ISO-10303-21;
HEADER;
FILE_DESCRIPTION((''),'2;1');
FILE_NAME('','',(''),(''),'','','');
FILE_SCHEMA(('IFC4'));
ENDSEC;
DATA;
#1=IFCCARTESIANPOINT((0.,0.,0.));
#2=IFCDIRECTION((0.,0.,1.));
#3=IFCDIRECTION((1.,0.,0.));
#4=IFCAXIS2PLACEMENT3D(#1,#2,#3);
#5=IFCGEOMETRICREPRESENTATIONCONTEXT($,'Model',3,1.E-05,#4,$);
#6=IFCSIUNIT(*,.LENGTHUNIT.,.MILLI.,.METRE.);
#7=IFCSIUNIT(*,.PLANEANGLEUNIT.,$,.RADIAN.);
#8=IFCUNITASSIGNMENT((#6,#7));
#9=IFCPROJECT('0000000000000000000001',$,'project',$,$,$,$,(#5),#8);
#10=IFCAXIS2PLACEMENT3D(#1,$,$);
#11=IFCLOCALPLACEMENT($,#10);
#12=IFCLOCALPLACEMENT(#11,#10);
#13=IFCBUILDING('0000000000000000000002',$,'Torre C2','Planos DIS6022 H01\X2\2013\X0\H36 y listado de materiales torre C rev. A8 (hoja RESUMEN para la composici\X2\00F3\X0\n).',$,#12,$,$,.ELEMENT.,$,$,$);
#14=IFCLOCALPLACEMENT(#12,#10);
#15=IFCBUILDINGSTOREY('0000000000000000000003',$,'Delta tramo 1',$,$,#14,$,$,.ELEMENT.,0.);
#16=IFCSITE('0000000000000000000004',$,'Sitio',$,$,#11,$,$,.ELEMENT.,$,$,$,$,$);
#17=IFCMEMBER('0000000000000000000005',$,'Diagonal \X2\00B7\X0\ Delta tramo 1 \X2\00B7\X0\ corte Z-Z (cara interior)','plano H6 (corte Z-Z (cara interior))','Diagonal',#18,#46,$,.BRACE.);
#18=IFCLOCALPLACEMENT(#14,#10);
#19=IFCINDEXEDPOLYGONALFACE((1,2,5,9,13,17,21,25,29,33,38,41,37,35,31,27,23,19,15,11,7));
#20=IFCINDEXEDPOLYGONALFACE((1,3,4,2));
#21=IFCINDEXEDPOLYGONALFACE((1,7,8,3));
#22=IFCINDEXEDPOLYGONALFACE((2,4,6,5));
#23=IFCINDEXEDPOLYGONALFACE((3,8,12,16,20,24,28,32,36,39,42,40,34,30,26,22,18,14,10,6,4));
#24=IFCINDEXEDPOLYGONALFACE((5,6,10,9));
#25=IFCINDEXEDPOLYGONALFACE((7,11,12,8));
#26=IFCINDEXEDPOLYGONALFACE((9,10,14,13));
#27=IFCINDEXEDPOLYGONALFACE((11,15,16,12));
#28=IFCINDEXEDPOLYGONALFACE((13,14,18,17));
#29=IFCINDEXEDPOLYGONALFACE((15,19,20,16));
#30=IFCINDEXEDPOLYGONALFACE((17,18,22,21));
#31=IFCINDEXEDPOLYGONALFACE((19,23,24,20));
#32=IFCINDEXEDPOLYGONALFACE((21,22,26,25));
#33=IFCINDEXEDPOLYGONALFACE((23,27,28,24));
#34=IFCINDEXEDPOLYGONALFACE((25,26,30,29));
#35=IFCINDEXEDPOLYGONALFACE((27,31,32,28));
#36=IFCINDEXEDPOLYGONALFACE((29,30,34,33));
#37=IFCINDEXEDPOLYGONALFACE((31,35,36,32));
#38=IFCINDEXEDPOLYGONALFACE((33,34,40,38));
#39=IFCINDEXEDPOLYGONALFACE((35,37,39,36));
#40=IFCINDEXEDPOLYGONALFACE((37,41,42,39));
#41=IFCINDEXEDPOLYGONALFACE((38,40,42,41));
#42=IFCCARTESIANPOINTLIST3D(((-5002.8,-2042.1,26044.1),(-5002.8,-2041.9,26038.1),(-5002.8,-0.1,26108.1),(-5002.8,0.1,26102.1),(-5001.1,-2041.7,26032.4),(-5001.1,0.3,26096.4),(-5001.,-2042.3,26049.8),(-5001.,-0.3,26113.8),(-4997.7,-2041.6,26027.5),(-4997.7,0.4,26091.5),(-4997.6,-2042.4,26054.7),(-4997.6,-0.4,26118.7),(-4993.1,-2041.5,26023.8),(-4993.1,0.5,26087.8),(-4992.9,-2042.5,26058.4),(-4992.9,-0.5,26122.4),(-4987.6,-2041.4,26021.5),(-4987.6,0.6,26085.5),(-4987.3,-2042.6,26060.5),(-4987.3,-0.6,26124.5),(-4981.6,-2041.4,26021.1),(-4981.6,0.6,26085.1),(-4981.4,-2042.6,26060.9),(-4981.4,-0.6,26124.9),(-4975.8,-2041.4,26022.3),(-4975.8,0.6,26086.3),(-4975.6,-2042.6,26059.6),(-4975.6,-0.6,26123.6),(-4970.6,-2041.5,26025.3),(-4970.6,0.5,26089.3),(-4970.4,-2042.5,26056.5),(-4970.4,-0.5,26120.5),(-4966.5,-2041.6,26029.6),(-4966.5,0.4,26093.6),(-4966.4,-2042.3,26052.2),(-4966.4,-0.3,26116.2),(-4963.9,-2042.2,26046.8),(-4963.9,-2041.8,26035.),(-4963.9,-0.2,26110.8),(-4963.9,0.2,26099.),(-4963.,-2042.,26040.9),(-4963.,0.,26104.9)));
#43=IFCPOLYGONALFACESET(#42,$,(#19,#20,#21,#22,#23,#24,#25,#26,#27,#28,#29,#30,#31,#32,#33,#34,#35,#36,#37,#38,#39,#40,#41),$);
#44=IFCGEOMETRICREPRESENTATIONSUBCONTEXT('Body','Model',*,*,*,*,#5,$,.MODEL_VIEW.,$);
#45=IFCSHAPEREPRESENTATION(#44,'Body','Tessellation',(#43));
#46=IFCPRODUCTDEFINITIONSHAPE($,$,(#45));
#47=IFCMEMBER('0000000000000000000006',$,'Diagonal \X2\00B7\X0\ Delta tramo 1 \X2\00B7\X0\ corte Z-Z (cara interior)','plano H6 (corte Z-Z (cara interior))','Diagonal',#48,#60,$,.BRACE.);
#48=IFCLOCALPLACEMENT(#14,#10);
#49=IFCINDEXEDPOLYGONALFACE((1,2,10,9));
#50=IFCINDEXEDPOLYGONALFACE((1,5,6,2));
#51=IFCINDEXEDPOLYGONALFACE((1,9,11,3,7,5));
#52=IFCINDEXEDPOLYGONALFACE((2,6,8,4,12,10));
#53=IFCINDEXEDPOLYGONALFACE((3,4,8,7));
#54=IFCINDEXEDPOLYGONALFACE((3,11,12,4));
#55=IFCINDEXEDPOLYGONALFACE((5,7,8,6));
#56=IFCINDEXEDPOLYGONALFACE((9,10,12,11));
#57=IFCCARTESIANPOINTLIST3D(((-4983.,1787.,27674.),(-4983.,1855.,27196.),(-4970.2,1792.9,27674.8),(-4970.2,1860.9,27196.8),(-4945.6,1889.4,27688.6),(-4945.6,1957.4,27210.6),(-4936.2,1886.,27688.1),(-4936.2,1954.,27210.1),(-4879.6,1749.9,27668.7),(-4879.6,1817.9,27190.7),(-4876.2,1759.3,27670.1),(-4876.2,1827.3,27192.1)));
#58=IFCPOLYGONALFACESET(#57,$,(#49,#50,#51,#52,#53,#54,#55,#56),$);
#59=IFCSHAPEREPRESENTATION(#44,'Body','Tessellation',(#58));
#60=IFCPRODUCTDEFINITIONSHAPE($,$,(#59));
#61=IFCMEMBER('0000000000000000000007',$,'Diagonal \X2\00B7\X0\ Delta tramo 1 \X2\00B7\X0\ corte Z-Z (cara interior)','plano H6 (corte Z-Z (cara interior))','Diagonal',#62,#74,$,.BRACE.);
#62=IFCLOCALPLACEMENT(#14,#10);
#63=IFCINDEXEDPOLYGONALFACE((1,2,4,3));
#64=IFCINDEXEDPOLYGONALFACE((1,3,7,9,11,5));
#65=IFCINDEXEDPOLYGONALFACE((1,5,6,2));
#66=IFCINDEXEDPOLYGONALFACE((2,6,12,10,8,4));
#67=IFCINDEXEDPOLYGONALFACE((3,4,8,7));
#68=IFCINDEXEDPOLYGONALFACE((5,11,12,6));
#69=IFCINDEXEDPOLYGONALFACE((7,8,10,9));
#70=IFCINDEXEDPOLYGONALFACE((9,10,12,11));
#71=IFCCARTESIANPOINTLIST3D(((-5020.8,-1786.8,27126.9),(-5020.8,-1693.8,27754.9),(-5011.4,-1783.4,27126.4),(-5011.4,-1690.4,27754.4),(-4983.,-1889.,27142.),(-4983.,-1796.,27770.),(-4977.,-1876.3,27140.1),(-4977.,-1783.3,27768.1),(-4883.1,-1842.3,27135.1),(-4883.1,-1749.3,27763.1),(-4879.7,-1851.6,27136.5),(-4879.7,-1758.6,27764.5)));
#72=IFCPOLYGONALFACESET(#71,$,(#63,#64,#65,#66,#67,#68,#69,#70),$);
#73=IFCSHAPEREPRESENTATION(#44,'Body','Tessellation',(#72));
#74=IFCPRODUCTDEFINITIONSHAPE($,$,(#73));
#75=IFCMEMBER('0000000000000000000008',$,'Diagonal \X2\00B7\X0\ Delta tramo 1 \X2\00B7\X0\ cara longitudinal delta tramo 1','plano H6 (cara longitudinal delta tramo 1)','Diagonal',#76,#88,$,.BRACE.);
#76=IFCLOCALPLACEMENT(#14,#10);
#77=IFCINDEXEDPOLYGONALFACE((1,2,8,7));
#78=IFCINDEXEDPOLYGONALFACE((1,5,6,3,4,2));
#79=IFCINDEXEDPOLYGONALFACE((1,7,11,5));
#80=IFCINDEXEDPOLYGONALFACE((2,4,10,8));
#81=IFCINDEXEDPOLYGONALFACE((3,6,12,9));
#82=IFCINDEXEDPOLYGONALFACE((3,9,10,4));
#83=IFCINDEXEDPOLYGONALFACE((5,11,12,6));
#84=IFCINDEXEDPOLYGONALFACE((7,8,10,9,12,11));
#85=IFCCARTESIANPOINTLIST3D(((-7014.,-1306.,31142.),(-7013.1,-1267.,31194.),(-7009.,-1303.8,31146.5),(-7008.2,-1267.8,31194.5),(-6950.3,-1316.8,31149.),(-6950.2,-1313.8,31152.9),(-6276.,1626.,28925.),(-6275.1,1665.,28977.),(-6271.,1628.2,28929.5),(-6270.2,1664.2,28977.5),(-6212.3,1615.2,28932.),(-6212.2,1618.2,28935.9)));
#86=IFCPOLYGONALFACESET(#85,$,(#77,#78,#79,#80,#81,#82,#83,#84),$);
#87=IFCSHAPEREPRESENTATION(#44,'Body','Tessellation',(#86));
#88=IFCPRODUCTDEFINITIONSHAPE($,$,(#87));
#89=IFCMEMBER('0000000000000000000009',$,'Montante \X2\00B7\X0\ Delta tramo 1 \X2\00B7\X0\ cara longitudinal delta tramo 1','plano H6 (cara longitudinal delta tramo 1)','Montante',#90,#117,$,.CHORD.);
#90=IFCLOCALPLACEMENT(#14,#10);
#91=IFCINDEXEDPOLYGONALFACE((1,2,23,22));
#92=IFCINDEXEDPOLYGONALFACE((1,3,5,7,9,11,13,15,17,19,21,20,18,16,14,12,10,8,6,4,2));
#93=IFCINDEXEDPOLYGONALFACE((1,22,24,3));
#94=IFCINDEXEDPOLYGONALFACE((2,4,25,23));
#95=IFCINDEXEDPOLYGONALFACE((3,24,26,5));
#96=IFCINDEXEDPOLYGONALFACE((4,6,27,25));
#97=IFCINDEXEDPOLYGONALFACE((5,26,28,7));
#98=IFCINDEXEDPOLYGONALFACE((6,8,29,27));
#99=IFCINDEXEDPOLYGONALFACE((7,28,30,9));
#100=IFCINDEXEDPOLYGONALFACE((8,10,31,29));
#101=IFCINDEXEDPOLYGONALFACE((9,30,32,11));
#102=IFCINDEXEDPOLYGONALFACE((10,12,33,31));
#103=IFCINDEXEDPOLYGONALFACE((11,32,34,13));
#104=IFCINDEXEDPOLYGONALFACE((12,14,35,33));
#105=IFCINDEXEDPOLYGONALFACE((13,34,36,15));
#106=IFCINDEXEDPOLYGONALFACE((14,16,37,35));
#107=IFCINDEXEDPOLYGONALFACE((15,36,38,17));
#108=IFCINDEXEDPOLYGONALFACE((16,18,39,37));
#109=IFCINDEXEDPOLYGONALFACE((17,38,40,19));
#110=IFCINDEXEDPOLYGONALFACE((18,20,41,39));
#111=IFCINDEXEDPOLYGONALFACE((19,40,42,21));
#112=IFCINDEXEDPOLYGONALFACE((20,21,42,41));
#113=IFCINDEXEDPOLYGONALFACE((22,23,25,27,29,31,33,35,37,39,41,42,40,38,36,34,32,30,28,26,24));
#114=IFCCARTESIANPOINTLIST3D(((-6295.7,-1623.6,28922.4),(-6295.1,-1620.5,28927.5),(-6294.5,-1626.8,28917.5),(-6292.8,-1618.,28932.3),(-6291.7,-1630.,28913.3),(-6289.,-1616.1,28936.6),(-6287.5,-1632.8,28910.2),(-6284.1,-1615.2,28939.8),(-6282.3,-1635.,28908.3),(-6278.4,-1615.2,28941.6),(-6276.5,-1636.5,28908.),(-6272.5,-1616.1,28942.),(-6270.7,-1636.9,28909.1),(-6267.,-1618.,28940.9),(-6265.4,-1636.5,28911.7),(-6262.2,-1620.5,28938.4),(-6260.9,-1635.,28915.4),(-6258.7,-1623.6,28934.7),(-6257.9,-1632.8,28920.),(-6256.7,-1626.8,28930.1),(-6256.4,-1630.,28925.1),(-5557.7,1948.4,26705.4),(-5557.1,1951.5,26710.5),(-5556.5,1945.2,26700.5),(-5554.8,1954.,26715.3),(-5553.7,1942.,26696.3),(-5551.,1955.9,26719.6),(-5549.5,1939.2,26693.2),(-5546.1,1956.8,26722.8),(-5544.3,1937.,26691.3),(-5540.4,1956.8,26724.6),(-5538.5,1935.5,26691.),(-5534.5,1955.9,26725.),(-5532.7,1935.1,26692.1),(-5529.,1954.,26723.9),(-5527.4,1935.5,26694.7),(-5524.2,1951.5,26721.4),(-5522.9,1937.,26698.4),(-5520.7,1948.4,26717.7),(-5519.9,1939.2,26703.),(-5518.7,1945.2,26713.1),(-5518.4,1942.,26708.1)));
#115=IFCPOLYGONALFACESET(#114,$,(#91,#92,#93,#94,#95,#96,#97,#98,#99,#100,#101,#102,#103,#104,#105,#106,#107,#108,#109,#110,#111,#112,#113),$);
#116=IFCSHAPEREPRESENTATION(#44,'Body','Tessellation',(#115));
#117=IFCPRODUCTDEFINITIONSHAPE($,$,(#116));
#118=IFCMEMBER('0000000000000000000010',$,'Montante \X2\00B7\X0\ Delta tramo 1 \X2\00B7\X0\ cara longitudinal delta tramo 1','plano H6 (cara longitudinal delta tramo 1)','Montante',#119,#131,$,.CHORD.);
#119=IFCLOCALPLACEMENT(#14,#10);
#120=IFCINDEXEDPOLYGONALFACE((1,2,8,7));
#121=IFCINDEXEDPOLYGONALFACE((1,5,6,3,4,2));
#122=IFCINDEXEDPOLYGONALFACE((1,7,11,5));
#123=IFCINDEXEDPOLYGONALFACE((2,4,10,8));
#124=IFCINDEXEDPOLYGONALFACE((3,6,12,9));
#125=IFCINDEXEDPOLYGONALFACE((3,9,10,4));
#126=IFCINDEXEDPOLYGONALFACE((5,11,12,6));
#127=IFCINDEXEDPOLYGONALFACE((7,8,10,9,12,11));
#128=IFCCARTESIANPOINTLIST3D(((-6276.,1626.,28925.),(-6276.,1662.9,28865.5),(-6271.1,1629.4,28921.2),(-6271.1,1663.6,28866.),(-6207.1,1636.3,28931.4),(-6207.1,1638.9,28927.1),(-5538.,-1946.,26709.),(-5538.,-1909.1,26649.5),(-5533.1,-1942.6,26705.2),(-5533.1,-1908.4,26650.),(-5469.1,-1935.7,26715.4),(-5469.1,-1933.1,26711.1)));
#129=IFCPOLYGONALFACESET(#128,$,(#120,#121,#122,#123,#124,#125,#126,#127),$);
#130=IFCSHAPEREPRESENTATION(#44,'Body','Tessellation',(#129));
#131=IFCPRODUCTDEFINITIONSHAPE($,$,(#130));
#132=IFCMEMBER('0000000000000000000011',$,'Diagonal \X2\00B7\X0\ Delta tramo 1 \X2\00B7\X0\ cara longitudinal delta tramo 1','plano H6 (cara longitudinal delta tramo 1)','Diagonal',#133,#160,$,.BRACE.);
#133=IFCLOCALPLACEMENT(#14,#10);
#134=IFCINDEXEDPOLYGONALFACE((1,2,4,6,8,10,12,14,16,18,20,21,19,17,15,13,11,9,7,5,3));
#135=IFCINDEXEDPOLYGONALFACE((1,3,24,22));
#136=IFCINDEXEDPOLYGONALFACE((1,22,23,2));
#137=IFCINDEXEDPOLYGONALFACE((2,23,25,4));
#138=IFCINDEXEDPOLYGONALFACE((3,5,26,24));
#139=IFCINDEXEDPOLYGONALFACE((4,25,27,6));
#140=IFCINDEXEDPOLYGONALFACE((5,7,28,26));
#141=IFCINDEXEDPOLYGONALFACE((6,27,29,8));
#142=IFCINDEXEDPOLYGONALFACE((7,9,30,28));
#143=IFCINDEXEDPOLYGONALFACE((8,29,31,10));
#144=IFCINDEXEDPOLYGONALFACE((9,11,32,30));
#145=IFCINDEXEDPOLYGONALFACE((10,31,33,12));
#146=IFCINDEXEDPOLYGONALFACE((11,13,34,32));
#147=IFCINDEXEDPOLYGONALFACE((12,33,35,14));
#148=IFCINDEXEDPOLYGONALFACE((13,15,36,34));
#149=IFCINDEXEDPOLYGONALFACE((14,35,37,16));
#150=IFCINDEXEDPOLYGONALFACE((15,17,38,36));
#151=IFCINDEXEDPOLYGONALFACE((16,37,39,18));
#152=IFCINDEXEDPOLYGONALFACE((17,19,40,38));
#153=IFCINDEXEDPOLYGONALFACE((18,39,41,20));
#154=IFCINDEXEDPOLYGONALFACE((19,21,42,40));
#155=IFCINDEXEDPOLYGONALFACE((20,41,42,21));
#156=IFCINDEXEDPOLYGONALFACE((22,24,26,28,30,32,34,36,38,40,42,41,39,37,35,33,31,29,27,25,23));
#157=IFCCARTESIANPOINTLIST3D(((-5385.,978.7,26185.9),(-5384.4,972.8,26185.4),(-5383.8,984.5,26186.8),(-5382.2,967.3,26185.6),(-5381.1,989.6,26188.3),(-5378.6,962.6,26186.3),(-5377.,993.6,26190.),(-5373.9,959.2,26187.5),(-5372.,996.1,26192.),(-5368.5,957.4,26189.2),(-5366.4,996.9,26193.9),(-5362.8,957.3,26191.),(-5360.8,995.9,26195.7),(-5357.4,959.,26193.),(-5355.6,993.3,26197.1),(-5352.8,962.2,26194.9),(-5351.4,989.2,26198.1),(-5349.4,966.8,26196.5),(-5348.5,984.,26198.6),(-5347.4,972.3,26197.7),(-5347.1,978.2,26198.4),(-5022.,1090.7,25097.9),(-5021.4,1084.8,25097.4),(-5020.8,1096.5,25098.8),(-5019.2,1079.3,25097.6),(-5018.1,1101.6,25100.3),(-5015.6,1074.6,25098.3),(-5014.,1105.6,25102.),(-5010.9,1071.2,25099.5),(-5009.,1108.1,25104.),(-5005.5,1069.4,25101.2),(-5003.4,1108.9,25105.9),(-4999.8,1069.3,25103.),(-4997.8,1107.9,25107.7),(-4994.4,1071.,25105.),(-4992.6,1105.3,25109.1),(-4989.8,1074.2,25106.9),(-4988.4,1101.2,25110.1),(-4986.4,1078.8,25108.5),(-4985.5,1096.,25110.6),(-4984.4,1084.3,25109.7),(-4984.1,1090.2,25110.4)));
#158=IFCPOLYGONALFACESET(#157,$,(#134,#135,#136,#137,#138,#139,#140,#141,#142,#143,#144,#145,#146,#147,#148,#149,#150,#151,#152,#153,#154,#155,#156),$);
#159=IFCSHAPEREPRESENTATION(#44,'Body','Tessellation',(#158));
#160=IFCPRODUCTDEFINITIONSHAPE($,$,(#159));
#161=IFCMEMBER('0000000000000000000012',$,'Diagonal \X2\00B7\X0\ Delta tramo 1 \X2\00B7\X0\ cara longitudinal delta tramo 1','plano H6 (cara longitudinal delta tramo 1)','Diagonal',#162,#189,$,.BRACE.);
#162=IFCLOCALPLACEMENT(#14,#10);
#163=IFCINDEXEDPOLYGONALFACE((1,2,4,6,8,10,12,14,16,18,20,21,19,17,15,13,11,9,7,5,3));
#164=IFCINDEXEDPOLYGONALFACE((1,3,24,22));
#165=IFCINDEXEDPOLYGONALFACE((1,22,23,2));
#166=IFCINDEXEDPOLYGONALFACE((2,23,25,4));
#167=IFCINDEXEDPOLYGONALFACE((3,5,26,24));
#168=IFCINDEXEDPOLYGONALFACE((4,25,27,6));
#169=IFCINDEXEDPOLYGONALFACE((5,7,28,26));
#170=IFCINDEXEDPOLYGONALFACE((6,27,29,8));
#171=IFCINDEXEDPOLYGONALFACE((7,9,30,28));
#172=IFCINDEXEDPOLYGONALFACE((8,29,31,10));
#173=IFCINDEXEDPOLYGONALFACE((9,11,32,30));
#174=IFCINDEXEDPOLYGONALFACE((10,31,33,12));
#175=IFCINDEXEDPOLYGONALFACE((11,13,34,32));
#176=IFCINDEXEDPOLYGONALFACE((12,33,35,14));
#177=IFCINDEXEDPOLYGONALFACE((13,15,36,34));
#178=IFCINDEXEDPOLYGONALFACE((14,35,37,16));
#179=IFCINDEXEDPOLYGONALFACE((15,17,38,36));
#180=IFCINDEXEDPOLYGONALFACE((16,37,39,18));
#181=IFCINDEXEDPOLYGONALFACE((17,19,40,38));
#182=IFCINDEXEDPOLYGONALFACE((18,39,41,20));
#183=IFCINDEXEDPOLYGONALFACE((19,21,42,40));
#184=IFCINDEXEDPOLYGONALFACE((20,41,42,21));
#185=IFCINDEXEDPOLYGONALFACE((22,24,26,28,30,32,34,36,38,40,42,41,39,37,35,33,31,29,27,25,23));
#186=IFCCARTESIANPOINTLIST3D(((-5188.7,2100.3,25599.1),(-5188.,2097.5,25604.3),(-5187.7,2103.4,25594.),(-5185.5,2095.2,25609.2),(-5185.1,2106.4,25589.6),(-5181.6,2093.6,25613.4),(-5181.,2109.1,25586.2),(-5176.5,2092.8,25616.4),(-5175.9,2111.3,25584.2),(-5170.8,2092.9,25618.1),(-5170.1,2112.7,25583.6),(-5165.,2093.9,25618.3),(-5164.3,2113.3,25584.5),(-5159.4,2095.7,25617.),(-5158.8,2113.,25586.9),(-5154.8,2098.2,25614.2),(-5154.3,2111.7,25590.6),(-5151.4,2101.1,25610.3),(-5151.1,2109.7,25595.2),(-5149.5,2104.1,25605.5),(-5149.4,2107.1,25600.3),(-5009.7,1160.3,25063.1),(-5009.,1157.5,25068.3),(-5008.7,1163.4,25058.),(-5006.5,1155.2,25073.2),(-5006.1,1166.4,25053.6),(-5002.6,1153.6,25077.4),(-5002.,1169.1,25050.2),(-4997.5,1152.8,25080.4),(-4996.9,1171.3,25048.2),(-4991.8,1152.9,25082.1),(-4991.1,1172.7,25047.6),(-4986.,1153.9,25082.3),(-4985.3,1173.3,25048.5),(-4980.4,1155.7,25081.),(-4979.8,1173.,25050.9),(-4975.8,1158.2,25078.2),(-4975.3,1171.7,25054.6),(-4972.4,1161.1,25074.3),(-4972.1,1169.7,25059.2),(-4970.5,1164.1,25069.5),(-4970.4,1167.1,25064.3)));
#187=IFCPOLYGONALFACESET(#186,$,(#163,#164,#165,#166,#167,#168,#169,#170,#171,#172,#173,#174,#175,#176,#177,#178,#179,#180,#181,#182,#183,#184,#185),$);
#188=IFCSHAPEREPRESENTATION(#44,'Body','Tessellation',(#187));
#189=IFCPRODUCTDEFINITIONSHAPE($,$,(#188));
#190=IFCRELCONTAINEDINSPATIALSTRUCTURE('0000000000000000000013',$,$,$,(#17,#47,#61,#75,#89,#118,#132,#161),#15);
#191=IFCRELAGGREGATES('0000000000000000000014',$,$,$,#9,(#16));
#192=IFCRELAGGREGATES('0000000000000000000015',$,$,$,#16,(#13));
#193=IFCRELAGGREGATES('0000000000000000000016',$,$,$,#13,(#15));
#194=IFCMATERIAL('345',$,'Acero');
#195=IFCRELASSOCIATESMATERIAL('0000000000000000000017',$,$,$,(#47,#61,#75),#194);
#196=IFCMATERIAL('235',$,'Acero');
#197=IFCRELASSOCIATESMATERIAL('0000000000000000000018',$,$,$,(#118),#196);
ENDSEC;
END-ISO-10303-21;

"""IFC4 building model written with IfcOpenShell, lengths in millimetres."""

from ifc_helpers import new_model, si_unit, frame, frame_2d, origin, origin_with_axes, place, context, subcontext, project, spatial, circle, l_section, extrude, material, element, save


model = new_model("IFC4")

# Units and contexts
model_context = context("Model", 3, precision=1e-05, world=origin_with_axes())
body_context = subcontext(model_context, "Body", "Model", "MODEL_VIEW")
ifc_project = project(units=[si_unit("LENGTHUNIT", "METRE", prefix="MILLI"), si_unit("PLANEANGLEUNIT", "RADIAN")], contexts=[model_context])

# Site, building, storey
site_placement = place(None, origin())
site = spatial("IfcSite", under=ifc_project, at=site_placement, Name="Sitio", CompositionType="ELEMENT")
building_placement = place(site_placement, origin())
building = spatial("IfcBuilding", under=site, at=building_placement, Name="Torre C2", Description="Planos DIS6022 H01–H36 y listado de materiales torre C rev. A8 (hoja RESUMEN para la composición).", CompositionType="ELEMENT")
storey_placement = place(building_placement, origin())
storey = spatial("IfcBuildingStorey", under=building, at=storey_placement, Name="Delta tramo 1", CompositionType="ELEMENT", Elevation=0.0)

# Members
ifc_material_1 = material(Name="235", Category="Acero")
member_1_placement = place(storey_placement, frame((-4983.0, -2042.0, 26041.0), z_axis=(0.0, 0.999509, 0.031326), x_axis=(0.999979, 0.000201, -0.006415)))
element("IfcMember", 1, at=member_1_placement, inside=storey, Name="Diagonal · Delta tramo 1 · corte Z-Z (cara interior)", Description="plano H6 (corte Z-Z (cara interior))", ObjectType="Diagonal", PredefinedType="BRACE", context=body_context, shape_type="SweptSolid", body=[
    extrude(circle(Radius=20.0), None, (0.0, 0.0, 1.0), 2043.0),
])
ifc_material_2 = material(Name="345", Category="Acero")
member_2_placement = place(storey_placement, frame((-4983.0, 1855.0, 27196.0), z_axis=(0.0, -0.140841, 0.990032), x_axis=(0.940347, -0.336826, -0.047917)))
element("IfcMember", 2, at=member_2_placement, inside=storey, material=ifc_material_2, Name="Diagonal · Delta tramo 1 · corte Z-Z (cara interior)", Description="plano H6 (corte Z-Z (cara interior))", ObjectType="Diagonal", PredefinedType="BRACE", context=body_context, shape_type="SweptSolid", body=[
    extrude(l_section(Depth=110.0, Width=110.0, Thickness=10.0, at=frame_2d((55.0, 55.0))), None, (0.0, 0.0, 1.0), 482.8),
])
member_3_placement = place(storey_placement, frame((-4983.0, -1889.0, 27142.0), z_axis=(0.0, 0.146492, 0.989212), x_axis=(0.939149, 0.339805, -0.050321)))
element("IfcMember", 3, at=member_3_placement, inside=storey, material=ifc_material_2, Name="Diagonal · Delta tramo 1 · corte Z-Z (cara interior)", Description="plano H6 (corte Z-Z (cara interior))", ObjectType="Diagonal", PredefinedType="BRACE", context=body_context, shape_type="SweptSolid", body=[
    extrude(l_section(Depth=110.0, Width=110.0, Thickness=10.0, at=frame_2d((55.0, 55.0))), None, (0.0, 0.0, 1.0), 634.8),
])
member_4_placement = place(storey_placement, frame((-6276.0, 1626.0, 28925.0), z_axis=(-0.196843, -0.782037, 0.591329), x_axis=(0.980328, -0.165892, 0.106941)))
element("IfcMember", 4, at=member_4_placement, inside=storey, material=ifc_material_2, Name="Diagonal · Delta tramo 1 · cara longitudinal delta tramo 1", Description="plano H6 (cara longitudinal delta tramo 1)", ObjectType="Diagonal", PredefinedType="BRACE", context=body_context, shape_type="SweptSolid", body=[
    extrude(l_section(Depth=65.0, Width=65.0, Thickness=5.0, at=frame_2d((32.5, 32.5))), None, (0.0, 0.0, 1.0), 3749.2),
])
member_5_placement = place(storey_placement, frame((-5538.0, 1946.0, 26708.0), z_axis=(-0.1729, -0.836855, 0.519403), x_axis=(0.264314, -0.547425, -0.794018)))
element("IfcMember", 5, at=member_5_placement, inside=storey, Name="Montante · Delta tramo 1 · cara longitudinal delta tramo 1", Description="plano H6 (cara longitudinal delta tramo 1)", ObjectType="Montante", PredefinedType="CHORD", context=body_context, shape_type="SweptSolid", body=[
    extrude(circle(Radius=20.0), None, (0.0, 0.0, 1.0), 4268.4),
])
member_6_placement = place(storey_placement, frame((-5538.0, -1946.0, 26709.0), z_axis=(-0.172921, 0.836957, 0.519232), x_axis=(0.984936, 0.146941, 0.091159)))
element("IfcMember", 6, at=member_6_placement, inside=storey, material=ifc_material_1, Name="Montante · Delta tramo 1 · cara longitudinal delta tramo 1", Description="plano H6 (cara longitudinal delta tramo 1)", ObjectType="Montante", PredefinedType="CHORD", context=body_context, shape_type="SweptSolid", body=[
    extrude(l_section(Depth=70.0, Width=70.0, Thickness=5.0, at=frame_2d((35.0, 35.0))), None, (0.0, 0.0, 1.0), 4267.8),
])
member_7_placement = place(storey_placement, frame((-5366.0, 977.0, 26192.0), z_axis=(0.314991, 0.097187, -0.944106), x_axis=(0.929313, -0.233618, 0.286007)))
element("IfcMember", 7, at=member_7_placement, inside=storey, Name="Diagonal · Delta tramo 1 · cara longitudinal delta tramo 1", Description="plano H6 (cara longitudinal delta tramo 1)", ObjectType="Diagonal", PredefinedType="BRACE", context=body_context, shape_type="SweptSolid", body=[
    extrude(circle(Radius=20.0), None, (0.0, 0.0, 1.0), 1152.4),
])
member_8_placement = place(storey_placement, frame((-5169.0, 2103.0, 25601.0), z_axis=(0.163204, -0.85705, -0.488701), x_axis=(0.972761, 0.057136, 0.224657)))
element("IfcMember", 8, at=member_8_placement, inside=storey, Name="Diagonal · Delta tramo 1 · cara longitudinal delta tramo 1", Description="plano H6 (cara longitudinal delta tramo 1)", ObjectType="Diagonal", PredefinedType="BRACE", context=body_context, shape_type="SweptSolid", body=[
    extrude(circle(Radius=20.0), None, (0.0, 0.0, 1.0), 1096.8),
])

save(model, "model.ifc")
